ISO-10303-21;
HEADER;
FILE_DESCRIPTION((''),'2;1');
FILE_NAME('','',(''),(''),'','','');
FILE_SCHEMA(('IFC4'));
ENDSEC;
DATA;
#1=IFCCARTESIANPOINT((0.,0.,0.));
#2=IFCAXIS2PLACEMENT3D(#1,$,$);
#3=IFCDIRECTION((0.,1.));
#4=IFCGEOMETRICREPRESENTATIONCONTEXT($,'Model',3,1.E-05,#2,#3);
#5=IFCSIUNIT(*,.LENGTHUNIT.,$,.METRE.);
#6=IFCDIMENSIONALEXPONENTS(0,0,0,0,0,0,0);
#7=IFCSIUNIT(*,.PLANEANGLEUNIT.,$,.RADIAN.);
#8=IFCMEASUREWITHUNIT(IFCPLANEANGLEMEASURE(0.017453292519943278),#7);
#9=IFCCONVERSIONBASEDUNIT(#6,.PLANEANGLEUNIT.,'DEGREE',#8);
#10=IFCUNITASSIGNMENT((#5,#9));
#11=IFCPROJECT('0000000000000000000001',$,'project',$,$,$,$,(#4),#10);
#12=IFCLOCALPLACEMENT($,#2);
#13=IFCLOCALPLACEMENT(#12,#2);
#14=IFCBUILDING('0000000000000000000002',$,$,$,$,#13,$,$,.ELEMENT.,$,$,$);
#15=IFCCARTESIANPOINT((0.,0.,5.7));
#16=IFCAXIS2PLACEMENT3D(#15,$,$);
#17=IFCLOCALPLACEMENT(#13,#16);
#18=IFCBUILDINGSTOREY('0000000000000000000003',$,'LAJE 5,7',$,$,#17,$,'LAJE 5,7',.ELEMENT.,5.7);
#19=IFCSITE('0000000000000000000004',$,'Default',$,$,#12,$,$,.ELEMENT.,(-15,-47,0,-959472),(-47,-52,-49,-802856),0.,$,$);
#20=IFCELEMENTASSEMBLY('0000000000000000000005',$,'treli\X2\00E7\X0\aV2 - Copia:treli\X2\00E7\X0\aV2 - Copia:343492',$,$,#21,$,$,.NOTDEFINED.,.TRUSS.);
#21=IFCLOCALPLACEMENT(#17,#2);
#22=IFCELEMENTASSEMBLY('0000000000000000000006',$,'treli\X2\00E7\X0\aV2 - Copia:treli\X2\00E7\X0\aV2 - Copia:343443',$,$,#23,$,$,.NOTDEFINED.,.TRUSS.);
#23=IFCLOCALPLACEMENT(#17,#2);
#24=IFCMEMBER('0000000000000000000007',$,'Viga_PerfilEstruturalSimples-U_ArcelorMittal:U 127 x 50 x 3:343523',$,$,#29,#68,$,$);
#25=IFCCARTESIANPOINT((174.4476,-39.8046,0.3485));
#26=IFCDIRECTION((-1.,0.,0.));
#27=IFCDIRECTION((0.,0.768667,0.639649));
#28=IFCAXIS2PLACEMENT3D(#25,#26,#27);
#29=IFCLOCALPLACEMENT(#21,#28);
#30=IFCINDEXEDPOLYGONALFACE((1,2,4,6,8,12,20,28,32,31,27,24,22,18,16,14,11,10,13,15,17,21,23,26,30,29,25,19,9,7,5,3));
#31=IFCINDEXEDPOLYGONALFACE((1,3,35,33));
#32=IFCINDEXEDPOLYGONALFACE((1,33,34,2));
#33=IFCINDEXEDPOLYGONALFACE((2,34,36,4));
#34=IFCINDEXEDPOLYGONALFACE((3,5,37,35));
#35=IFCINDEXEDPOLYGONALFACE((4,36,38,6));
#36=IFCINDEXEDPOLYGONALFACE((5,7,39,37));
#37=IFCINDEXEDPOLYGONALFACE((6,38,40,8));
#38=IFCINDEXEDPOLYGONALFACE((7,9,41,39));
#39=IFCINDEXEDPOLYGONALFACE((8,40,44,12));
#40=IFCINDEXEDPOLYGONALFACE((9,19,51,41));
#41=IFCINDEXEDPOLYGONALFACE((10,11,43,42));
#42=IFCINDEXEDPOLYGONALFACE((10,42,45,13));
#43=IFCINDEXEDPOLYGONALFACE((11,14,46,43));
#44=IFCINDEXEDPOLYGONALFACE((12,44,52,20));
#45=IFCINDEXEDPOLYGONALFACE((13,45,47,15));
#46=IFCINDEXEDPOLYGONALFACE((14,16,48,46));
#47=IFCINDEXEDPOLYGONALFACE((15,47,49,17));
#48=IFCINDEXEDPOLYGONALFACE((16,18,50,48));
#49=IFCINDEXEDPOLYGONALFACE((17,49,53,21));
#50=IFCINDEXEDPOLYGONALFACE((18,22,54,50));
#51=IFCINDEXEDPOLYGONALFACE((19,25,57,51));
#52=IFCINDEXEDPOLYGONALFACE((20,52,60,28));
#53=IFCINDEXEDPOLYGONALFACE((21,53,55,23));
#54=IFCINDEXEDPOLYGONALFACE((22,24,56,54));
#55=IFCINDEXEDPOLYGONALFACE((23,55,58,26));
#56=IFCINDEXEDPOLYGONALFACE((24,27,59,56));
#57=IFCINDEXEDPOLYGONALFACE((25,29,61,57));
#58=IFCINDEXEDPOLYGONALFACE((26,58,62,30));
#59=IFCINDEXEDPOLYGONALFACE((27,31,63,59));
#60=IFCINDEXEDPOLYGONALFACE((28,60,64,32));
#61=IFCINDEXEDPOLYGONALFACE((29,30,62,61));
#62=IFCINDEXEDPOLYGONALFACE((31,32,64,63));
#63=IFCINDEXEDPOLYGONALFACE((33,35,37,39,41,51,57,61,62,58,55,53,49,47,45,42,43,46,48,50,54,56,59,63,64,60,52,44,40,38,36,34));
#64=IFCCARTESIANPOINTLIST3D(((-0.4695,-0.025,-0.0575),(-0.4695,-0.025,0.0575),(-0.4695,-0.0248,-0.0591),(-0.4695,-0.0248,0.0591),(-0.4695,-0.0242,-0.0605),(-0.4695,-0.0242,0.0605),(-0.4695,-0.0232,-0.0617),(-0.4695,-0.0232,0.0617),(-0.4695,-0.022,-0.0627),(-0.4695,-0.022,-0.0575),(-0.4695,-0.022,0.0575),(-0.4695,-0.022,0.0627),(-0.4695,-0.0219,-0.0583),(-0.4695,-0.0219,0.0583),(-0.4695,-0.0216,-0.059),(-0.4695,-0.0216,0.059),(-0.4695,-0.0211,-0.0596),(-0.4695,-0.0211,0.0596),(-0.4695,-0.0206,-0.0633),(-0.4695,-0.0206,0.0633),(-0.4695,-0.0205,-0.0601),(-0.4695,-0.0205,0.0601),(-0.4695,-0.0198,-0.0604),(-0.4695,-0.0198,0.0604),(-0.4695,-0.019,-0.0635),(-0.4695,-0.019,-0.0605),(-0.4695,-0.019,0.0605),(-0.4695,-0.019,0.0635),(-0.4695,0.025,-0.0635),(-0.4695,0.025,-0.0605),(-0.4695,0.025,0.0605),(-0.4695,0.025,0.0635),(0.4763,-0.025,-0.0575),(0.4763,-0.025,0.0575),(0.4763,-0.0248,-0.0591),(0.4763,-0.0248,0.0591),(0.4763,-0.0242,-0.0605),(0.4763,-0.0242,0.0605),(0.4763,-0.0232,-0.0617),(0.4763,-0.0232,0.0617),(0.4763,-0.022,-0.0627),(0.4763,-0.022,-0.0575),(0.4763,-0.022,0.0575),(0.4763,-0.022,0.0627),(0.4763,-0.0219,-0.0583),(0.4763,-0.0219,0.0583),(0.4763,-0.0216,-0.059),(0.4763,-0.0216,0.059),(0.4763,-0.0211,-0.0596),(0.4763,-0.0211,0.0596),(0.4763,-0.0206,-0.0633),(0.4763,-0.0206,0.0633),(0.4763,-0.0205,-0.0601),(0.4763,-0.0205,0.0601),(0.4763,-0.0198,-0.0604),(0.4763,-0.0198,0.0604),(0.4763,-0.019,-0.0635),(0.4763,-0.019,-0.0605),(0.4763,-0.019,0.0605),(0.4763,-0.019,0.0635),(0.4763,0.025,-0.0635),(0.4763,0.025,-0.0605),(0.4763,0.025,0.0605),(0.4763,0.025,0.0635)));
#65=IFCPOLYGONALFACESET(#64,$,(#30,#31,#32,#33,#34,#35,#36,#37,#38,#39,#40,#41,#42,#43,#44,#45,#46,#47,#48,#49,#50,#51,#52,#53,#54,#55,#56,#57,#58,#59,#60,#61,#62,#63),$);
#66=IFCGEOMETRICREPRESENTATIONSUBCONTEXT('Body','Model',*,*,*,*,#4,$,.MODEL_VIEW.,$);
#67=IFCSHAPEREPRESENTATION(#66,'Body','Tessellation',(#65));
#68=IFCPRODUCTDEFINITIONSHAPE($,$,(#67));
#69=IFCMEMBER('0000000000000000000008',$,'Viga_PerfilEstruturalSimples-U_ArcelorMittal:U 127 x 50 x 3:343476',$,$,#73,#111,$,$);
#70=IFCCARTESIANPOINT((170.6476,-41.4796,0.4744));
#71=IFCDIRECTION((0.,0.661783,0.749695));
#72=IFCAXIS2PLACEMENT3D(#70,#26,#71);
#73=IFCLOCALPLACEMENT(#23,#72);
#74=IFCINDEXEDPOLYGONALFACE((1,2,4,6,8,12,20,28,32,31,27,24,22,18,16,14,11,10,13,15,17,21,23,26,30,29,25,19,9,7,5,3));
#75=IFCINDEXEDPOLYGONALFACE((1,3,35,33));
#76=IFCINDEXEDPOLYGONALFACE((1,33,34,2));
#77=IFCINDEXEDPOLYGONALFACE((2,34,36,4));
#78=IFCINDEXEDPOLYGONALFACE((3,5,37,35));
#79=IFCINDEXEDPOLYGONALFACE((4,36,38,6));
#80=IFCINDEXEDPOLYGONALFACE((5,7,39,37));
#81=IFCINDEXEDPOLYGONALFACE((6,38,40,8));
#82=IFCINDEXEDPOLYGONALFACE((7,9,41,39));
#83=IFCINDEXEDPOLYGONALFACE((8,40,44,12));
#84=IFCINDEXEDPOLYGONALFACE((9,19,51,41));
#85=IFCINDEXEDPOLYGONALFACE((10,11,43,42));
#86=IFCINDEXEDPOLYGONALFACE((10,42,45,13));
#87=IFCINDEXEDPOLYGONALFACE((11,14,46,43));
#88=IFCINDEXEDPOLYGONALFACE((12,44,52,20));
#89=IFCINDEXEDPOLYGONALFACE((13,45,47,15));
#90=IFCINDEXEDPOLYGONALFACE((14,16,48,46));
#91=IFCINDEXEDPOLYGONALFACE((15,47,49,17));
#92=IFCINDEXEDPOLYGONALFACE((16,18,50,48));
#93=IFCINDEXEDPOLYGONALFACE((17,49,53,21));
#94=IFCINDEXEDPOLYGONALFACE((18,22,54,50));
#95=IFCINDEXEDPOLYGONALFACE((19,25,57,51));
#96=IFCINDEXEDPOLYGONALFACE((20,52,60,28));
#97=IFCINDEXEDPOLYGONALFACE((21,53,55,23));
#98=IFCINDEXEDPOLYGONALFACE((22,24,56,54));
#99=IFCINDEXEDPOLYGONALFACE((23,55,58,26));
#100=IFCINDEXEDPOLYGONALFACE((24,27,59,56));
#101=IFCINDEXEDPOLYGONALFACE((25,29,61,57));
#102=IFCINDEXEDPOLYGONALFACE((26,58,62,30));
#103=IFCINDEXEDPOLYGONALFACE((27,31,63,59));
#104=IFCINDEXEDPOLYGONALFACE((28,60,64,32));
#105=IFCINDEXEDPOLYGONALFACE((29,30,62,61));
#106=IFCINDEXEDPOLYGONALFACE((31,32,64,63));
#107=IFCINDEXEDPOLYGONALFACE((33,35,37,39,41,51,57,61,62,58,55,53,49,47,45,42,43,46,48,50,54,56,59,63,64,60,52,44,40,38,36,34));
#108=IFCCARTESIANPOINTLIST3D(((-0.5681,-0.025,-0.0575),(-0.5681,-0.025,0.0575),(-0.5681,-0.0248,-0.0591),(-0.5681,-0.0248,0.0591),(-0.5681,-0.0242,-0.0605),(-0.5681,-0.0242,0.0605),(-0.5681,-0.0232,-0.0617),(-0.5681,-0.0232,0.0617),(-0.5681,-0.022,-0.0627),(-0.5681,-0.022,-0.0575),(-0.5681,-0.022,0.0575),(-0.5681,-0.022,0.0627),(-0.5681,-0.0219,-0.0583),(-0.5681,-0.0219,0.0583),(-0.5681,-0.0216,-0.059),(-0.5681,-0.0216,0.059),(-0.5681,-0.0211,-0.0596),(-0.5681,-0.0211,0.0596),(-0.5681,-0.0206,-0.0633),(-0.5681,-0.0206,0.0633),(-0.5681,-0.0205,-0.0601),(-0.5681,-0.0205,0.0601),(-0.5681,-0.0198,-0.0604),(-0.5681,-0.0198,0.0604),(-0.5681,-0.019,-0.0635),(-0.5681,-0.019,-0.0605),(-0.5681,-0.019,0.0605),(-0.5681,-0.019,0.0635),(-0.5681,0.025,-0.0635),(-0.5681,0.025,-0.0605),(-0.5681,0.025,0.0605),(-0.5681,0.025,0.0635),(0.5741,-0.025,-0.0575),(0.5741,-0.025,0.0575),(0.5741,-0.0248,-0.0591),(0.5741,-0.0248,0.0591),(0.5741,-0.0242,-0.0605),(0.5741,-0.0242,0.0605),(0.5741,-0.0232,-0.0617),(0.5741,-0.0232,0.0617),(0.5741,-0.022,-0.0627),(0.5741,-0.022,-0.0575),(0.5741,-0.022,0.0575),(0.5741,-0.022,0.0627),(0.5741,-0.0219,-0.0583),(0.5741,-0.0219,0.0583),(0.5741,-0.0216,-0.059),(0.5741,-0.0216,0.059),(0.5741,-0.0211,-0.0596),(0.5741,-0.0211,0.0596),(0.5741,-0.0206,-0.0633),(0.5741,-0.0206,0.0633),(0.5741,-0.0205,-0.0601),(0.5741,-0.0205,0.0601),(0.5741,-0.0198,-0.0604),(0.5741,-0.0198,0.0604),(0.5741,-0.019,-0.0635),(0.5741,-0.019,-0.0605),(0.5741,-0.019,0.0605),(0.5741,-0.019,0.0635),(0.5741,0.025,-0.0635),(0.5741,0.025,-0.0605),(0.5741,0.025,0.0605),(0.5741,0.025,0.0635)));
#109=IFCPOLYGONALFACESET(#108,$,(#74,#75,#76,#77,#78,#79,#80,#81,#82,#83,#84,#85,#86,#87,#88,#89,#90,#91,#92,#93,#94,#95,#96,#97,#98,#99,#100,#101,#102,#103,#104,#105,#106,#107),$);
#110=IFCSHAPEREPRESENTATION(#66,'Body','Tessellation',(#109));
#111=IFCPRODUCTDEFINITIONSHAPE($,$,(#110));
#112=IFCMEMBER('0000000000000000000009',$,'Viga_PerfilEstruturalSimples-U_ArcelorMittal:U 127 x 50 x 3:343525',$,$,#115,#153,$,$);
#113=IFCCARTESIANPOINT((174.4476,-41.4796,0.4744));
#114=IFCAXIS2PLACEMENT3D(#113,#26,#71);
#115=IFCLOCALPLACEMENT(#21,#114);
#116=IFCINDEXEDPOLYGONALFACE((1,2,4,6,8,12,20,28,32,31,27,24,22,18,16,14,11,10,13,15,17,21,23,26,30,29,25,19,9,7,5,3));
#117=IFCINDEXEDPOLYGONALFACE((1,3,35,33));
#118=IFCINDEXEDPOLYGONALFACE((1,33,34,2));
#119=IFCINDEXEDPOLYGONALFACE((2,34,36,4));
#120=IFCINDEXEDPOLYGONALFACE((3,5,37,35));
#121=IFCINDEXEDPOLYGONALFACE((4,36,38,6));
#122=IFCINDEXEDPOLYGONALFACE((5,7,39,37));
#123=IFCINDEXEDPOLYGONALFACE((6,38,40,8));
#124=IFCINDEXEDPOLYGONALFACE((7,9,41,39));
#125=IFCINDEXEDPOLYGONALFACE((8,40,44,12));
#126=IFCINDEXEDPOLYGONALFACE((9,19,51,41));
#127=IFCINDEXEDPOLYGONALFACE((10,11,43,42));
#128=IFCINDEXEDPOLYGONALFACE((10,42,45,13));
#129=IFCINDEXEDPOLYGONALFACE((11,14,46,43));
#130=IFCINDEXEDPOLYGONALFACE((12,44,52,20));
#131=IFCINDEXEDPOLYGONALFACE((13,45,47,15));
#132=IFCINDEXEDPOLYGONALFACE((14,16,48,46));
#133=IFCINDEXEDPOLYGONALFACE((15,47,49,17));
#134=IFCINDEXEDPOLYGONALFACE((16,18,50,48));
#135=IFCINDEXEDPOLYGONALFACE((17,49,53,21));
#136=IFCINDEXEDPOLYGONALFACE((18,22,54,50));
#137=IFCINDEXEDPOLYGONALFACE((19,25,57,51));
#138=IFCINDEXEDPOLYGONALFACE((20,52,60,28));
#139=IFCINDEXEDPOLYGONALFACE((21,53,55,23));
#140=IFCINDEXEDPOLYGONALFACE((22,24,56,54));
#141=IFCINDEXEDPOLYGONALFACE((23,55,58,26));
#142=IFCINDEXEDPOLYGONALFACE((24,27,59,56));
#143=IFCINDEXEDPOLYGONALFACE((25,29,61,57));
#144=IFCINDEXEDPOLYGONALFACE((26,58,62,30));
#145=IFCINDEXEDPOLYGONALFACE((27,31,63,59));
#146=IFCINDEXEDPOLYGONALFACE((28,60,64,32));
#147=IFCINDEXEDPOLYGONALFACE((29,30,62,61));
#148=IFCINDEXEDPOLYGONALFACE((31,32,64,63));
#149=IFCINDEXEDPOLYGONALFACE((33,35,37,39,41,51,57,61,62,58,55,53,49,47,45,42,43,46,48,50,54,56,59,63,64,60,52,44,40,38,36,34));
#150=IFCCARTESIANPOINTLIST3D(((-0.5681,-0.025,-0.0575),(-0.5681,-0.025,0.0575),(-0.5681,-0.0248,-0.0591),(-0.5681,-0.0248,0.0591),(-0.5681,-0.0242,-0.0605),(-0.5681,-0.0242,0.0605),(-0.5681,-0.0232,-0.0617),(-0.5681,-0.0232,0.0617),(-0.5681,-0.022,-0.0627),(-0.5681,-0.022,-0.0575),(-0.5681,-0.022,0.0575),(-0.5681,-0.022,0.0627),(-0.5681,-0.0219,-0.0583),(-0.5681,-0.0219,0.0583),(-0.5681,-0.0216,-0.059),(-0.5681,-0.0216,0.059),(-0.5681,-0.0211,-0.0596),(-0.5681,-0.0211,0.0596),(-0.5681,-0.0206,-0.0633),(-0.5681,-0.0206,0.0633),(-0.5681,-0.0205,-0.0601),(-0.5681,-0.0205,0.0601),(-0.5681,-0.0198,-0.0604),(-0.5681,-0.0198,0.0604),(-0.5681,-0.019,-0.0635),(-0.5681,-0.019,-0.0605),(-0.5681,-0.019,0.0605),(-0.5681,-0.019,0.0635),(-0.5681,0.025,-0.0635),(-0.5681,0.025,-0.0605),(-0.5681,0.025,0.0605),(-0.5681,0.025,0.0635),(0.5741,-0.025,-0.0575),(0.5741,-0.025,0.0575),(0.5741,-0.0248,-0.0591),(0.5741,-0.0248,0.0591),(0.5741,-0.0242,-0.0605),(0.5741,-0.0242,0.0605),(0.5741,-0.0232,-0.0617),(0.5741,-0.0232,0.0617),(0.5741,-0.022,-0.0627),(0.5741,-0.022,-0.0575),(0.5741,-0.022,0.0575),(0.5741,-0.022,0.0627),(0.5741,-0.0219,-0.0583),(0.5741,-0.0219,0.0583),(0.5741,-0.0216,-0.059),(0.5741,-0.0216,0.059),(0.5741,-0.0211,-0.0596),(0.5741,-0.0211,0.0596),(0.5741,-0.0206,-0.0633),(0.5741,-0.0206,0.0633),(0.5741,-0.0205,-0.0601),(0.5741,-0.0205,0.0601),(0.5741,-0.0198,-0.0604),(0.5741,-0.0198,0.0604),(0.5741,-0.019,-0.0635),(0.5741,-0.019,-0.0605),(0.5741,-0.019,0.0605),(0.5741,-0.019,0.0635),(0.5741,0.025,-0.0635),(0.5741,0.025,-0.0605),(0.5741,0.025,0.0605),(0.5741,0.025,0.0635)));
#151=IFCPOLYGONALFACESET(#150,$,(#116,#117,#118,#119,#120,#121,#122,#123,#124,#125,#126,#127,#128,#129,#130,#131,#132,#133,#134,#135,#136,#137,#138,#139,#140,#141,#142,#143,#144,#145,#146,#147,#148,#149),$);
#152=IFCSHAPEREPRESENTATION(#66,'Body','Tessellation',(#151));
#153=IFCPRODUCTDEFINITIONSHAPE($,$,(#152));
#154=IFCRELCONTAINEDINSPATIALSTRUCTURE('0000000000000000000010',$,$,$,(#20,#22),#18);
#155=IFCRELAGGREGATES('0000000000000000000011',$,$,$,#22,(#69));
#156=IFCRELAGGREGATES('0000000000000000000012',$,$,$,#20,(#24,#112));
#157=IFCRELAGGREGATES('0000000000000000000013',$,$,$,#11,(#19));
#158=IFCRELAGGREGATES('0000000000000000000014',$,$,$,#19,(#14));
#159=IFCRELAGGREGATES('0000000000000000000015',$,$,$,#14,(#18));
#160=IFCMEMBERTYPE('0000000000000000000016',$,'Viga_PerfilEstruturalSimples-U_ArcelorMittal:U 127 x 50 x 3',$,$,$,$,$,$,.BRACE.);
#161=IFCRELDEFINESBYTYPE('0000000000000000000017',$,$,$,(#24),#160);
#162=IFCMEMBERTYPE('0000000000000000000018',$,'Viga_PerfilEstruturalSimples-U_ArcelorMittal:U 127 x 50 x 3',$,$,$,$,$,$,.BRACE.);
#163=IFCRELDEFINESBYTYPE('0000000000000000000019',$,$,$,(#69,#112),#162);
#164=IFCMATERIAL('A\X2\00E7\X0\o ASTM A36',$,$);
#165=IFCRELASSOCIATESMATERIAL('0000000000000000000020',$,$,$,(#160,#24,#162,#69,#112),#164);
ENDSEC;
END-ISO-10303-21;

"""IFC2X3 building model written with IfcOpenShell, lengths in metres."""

from ifc_helpers import new_model, entity, si_unit, converted_unit, direction, frame, frame_2d, origin, place, context, subcontext, project, spatial, polyline, circle_curve, parameter, trimmed, segment, composite_curve, outline, extrude, source, transform, mapped, material, type_object, type_shapes, element, aggregate, save


model = new_model("IFC2X3")

# Units and contexts
model_context = context("Model", 3, precision=1e-05, world=origin(), true_north=direction((0.0, 1.0)))
body_context = subcontext(model_context, "Body", "Model", "MODEL_VIEW")
ifc_project = project(units=[si_unit("LENGTHUNIT", "METRE"), converted_unit("PLANEANGLEUNIT", "DEGREE", entity("IfcPlaneAngleMeasure", 0.017453292519943278), si_unit("PLANEANGLEUNIT", "RADIAN"), dimensions=[0, 0, 0, 0, 0, 0, 0])], contexts=[model_context])

# Site, building, storey
site_placement = place(None, origin())
site = spatial("IfcSite", under=ifc_project, at=site_placement, Name="Default", CompositionType="ELEMENT", RefLatitude=(-15, -47, 0, -959472), RefLongitude=(-47, -52, -49, -802856), RefElevation=0.0)
building_placement = place(site_placement, origin())
building = spatial("IfcBuilding", under=site, at=building_placement, CompositionType="ELEMENT")
storey_placement = place(building_placement, frame((0.0, 0.0, 5.7)))
storey = spatial("IfcBuildingStorey", under=building, at=storey_placement, Name="LAJE 5,7", LongName="LAJE 5,7", CompositionType="ELEMENT", Elevation=5.7)

# Element assembly
assembly_1_placement = place(storey_placement, origin())
assembly_1 = element("IfcElementAssembly", 1, at=assembly_1_placement, inside=storey, Name="treliçaV2 - Copia:treliçaV2 - Copia:343492", AssemblyPlace="NOTDEFINED", PredefinedType="TRUSS")
ifc_material = material(Name="Aço ASTM A36")

# Element assembly
assembly_2_placement = place(storey_placement, origin())
assembly_2 = element("IfcElementAssembly", 2, at=assembly_2_placement, inside=storey, Name="treliçaV2 - Copia:treliçaV2 - Copia:343443", AssemblyPlace="NOTDEFINED", PredefinedType="TRUSS")

# Members
member_type_1 = type_object("IfcMemberType", Name="Viga_PerfilEstruturalSimples-U_ArcelorMittal:U 127 x 50 x 3", PredefinedType="BRACE", material=ifc_material)
shared_shape_1 = source(origin(), body_context, "Body", "SweptSolid", [
    extrude(outline(composite_curve([segment(polyline([(-0.0575, -0.0192), (0.0575, -0.0192)]), True, "CONTINUOUS"), segment(trimmed(circle_curve(frame_2d((0.0575, -0.0132), x_axis=(0.0, 1.0)), 0.006), [parameter(180.0)], [parameter(270.0)], True, "PARAMETER"), True, "CONTINUOUS"), segment(polyline([(0.0635, -0.0132), (0.0635, 0.0308)]), True, "CONTINUOUS"), segment(polyline([(0.0635, 0.0308), (0.0605, 0.0308)]), True, "CONTINUOUS"), segment(polyline([(0.0605, 0.0308), (0.0605, -0.0132)]), True, "CONTINUOUS"), segment(trimmed(circle_curve(frame_2d((0.0575, -0.0132), x_axis=(0.0, 1.0)), 0.003), [parameter(180.0)], [parameter(270.0)], True, "PARAMETER"), False, "CONTINUOUS"), segment(polyline([(0.0575, -0.0162), (-0.0575, -0.0162)]), True, "CONTINUOUS"), segment(trimmed(circle_curve(frame_2d((-0.0575, -0.0132), x_axis=(0.0, 1.0)), 0.003), [parameter(90.0)], [parameter(180.0)], True, "PARAMETER"), False, "CONTINUOUS"), segment(polyline([(-0.0605, -0.0132), (-0.0605, 0.0308)]), True, "CONTINUOUS"), segment(polyline([(-0.0605, 0.0308), (-0.0635, 0.0308)]), True, "CONTINUOUS"), segment(polyline([(-0.0635, 0.0308), (-0.0635, -0.0132)]), True, "CONTINUOUS"), segment(trimmed(circle_curve(frame_2d((-0.0575, -0.0132), x_axis=(0.0, 1.0)), 0.006), [parameter(90.0)], [parameter(180.0)], True, "PARAMETER"), True, "CONTINUOUS")], self_intersect=False)), frame((-0.4695, -0.0058, 0.0), z_axis=(1.0, 0.0, 0.0), x_axis=(0.0, 0.0, -1.0)), (0.0, 0.0, 1.0), 0.9459),
])
type_shapes(member_type_1, [shared_shape_1])
member_1_placement = place(assembly_1_placement, frame((174.4476, -39.8046, 0.3485), z_axis=(-1.0, 0.0, 0.0), x_axis=(0.0, 0.768667, 0.639649)))
member_1 = element("IfcMember", 3, at=member_1_placement, type_object=member_type_1, material=ifc_material, Name="Viga_PerfilEstruturalSimples-U_ArcelorMittal:U 127 x 50 x 3:343523", context=body_context, shape_type="MappedRepresentation", body=[
    mapped(shared_shape_1, transform((0.0, 0.0, 0.0), scale=1.0)),
])
member_type_2 = type_object("IfcMemberType", Name="Viga_PerfilEstruturalSimples-U_ArcelorMittal:U 127 x 50 x 3", PredefinedType="BRACE", material=ifc_material)
shared_shape_2 = source(origin(), body_context, "Body", "SweptSolid", [
    extrude(outline(composite_curve([segment(polyline([(-0.0575, -0.0192), (0.0575, -0.0192)]), True, "CONTINUOUS"), segment(trimmed(circle_curve(frame_2d((0.0575, -0.0132), x_axis=(0.0, 1.0)), 0.006), [parameter(180.0)], [parameter(270.0)], True, "PARAMETER"), True, "CONTINUOUS"), segment(polyline([(0.0635, -0.0132), (0.0635, 0.0308)]), True, "CONTINUOUS"), segment(polyline([(0.0635, 0.0308), (0.0605, 0.0308)]), True, "CONTINUOUS"), segment(polyline([(0.0605, 0.0308), (0.0605, -0.0132)]), True, "CONTINUOUS"), segment(trimmed(circle_curve(frame_2d((0.0575, -0.0132), x_axis=(0.0, 1.0)), 0.003), [parameter(180.0)], [parameter(270.0)], True, "PARAMETER"), False, "CONTINUOUS"), segment(polyline([(0.0575, -0.0162), (-0.0575, -0.0162)]), True, "CONTINUOUS"), segment(trimmed(circle_curve(frame_2d((-0.0575, -0.0132), x_axis=(0.0, 1.0)), 0.003), [parameter(90.0)], [parameter(180.0)], True, "PARAMETER"), False, "CONTINUOUS"), segment(polyline([(-0.0605, -0.0132), (-0.0605, 0.0308)]), True, "CONTINUOUS"), segment(polyline([(-0.0605, 0.0308), (-0.0635, 0.0308)]), True, "CONTINUOUS"), segment(polyline([(-0.0635, 0.0308), (-0.0635, -0.0132)]), True, "CONTINUOUS"), segment(trimmed(circle_curve(frame_2d((-0.0575, -0.0132), x_axis=(0.0, 1.0)), 0.006), [parameter(90.0)], [parameter(180.0)], True, "PARAMETER"), True, "CONTINUOUS")], self_intersect=False)), frame((-0.5681, -0.0058, 0.0), z_axis=(1.0, 0.0, 0.0), x_axis=(0.0, 0.0, -1.0)), (0.0, 0.0, 1.0), 1.1422),
])
type_shapes(member_type_2, [shared_shape_2])
member_2_placement = place(assembly_2_placement, frame((170.6476, -41.4796, 0.4744), z_axis=(-1.0, 0.0, 0.0), x_axis=(0.0, 0.661783, 0.749695)))
member_2 = element("IfcMember", 4, at=member_2_placement, type_object=member_type_2, material=ifc_material, Name="Viga_PerfilEstruturalSimples-U_ArcelorMittal:U 127 x 50 x 3:343476", context=body_context, shape_type="MappedRepresentation", body=[
    mapped(shared_shape_2, transform((0.0, 0.0, 0.0), scale=1.0)),
])
member_3_placement = place(assembly_1_placement, frame((174.4476, -41.4796, 0.4744), z_axis=(-1.0, 0.0, 0.0), x_axis=(0.0, 0.661783, 0.749695)))
member_3 = element("IfcMember", 5, at=member_3_placement, type_object=member_type_2, material=ifc_material, Name="Viga_PerfilEstruturalSimples-U_ArcelorMittal:U 127 x 50 x 3:343525", context=body_context, shape_type="MappedRepresentation", body=[
    mapped(shared_shape_2, transform((0.0, 0.0, 0.0), scale=1.0)),
])
aggregate(assembly_2, [member_2])
aggregate(assembly_1, [member_1, member_3])

save(model, "model.ifc")
